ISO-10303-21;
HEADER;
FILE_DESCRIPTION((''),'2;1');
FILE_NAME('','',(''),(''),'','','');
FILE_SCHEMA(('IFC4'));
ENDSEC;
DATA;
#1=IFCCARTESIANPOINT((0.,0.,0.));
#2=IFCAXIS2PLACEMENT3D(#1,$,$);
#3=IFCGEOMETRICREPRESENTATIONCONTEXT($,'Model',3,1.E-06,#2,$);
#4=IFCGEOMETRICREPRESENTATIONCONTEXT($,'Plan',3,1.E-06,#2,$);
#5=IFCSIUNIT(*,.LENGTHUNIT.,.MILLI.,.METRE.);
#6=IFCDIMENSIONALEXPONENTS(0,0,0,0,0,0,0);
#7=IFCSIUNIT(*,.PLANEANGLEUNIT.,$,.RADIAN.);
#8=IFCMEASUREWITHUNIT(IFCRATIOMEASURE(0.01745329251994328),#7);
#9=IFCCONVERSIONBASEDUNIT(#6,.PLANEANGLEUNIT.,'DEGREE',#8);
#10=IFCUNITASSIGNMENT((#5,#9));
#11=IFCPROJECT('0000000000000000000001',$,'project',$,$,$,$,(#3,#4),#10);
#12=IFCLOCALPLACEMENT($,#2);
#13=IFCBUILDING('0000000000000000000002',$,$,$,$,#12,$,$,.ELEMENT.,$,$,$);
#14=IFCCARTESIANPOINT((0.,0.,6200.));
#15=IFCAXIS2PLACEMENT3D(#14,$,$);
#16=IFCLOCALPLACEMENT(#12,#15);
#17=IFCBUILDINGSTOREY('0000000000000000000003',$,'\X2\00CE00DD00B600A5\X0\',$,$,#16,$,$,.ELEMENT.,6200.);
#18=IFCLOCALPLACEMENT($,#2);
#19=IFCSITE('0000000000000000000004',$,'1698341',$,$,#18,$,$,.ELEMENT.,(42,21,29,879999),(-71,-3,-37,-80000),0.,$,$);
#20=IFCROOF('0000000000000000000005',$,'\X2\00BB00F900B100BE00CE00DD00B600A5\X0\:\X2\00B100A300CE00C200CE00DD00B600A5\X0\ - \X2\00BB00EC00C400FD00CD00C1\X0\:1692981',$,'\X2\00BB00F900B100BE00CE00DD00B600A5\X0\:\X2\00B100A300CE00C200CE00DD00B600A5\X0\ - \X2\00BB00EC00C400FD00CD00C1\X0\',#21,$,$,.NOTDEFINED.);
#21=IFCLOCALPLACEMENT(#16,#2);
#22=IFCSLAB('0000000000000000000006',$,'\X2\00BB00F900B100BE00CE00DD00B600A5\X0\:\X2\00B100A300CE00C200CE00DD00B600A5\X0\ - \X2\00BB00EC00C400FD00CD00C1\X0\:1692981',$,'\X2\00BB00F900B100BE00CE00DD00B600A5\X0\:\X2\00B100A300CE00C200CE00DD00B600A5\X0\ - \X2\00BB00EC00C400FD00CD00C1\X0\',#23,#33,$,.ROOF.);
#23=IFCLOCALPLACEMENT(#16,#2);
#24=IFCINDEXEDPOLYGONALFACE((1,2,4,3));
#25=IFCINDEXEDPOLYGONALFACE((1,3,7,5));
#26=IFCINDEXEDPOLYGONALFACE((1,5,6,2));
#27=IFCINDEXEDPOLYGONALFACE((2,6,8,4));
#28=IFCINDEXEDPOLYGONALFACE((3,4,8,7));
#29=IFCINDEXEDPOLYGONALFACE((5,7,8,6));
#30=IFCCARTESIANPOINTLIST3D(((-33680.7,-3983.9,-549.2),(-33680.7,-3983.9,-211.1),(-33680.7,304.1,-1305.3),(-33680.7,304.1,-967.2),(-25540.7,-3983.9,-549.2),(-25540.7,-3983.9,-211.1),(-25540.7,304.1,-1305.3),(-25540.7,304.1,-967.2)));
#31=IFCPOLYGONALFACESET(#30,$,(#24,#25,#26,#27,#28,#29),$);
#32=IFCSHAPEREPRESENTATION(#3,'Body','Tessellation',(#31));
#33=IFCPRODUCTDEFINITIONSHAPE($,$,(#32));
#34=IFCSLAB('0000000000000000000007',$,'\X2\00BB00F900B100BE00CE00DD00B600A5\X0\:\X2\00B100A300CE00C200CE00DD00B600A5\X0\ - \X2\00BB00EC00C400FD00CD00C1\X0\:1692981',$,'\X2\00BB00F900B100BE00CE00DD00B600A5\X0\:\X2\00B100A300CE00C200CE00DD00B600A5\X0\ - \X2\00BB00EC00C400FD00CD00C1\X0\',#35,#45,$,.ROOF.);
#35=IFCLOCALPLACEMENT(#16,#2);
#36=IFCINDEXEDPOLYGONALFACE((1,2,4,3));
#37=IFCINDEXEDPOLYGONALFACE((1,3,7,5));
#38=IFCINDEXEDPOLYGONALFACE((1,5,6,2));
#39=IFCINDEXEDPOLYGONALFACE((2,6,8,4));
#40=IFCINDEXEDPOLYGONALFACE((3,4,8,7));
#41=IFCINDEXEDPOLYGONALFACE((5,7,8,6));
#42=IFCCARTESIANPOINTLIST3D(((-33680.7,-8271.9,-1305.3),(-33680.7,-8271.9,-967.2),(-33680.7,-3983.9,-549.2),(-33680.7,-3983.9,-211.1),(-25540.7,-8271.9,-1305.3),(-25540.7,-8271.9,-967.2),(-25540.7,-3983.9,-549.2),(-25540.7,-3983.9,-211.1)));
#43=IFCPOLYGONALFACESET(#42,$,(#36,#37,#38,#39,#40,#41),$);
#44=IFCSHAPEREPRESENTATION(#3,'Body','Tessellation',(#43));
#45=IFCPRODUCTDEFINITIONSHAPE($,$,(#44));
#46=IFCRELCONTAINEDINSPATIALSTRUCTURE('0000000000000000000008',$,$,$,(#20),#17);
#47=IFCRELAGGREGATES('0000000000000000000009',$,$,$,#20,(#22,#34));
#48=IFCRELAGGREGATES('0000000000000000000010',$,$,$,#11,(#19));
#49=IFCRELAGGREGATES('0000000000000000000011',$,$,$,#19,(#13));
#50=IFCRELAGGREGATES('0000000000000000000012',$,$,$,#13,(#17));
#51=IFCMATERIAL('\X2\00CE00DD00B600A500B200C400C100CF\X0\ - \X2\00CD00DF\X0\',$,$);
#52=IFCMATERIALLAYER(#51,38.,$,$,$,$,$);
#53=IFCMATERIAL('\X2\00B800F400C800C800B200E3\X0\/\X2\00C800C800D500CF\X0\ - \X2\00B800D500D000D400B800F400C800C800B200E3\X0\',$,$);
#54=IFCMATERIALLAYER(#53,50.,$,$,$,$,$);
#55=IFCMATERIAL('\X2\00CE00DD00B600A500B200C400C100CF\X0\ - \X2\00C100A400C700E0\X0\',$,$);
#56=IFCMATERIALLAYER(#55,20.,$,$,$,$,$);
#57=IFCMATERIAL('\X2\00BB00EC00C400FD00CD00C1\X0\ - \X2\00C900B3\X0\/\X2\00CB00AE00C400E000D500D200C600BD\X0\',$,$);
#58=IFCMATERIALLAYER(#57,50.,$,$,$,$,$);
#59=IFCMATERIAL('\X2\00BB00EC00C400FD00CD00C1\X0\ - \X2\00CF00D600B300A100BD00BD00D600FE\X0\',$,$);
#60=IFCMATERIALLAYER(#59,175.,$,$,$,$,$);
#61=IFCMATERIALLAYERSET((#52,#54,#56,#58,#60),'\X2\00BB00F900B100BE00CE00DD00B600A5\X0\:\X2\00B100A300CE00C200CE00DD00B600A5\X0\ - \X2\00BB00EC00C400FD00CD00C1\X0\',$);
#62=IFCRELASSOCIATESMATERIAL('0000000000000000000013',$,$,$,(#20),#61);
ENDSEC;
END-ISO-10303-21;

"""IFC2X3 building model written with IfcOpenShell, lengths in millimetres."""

from ifc_helpers import new_model, entity, si_unit, converted_unit, frame, frame_2d, origin, place, context, project, spatial, rectangle, extrude, material, layer, layer_set, layer_usage, element, aggregate, save


model = new_model("IFC2X3")

# Units and contexts
model_context = context("Model", 3, precision=1e-06, world=origin())
plan_context = context("Plan", 3, precision=1e-06, world=origin())
ifc_project = project(units=[si_unit("LENGTHUNIT", "METRE", prefix="MILLI"), converted_unit("PLANEANGLEUNIT", "DEGREE", entity("IfcRatioMeasure", 0.01745329251994328), si_unit("PLANEANGLEUNIT", "RADIAN"), dimensions=[0, 0, 0, 0, 0, 0, 0])], contexts=[model_context, plan_context])

# Site, building, storey
site_placement = place(None, origin())
site = spatial("IfcSite", under=ifc_project, at=site_placement, Name="1698341", CompositionType="ELEMENT", RefLatitude=(42, 21, 29, 879999), RefLongitude=(-71, -3, -37, -80000), RefElevation=0.0)
building_placement = place(None, origin())
building = spatial("IfcBuilding", under=site, at=building_placement, CompositionType="ELEMENT")
storey_placement = place(building_placement, frame((0.0, 0.0, 6200.0)))
storey = spatial("IfcBuildingStorey", under=building, at=storey_placement, Name="ÎÝ¶¥", CompositionType="ELEMENT", Elevation=6200.0)

# Roof, slabs
ifc_material_1 = material(Name="ÎÝ¶¥²ÄÁÏ - Íß")
ifc_layer_1 = layer(ifc_material_1, 38.0)
ifc_material_2 = material(Name="¸ôÈÈ²ã/ÈÈÕÏ - ¸ÕÐÔ¸ôÈÈ²ã")
ifc_layer_2 = layer(ifc_material_2, 50.0)
ifc_material_3 = material(Name="ÎÝ¶¥²ÄÁÏ - Á¤Çà")
ifc_layer_3 = layer(ifc_material_3, 20.0)
ifc_material_4 = material(Name="»ìÄýÍÁ - É³/Ë®ÄàÕÒÆ½")
ifc_layer_4 = layer(ifc_material_4, 50.0)
ifc_material_5 = material(Name="»ìÄýÍÁ - ÏÖ³¡½½Öþ")
ifc_layer_5 = layer(ifc_material_5, 175.0)
ifc_layer_set = layer_set([ifc_layer_1, ifc_layer_2, ifc_layer_3, ifc_layer_4, ifc_layer_5], Name="»ù±¾ÎÝ¶¥:±£ÎÂÎÝ¶¥ - »ìÄýÍÁ")
ifc_layer_usage = layer_usage(ifc_layer_set, "AXIS3", "NEGATIVE", 0.0)
roof_placement = place(storey_placement, origin())
roof = element("IfcRoof", 1, at=roof_placement, inside=storey, material=ifc_layer_usage, Name="»ù±¾ÎÝ¶¥:±£ÎÂÎÝ¶¥ - »ìÄýÍÁ:1692981", ObjectType="»ù±¾ÎÝ¶¥:±£ÎÂÎÝ¶¥ - »ìÄýÍÁ", ShapeType="NOTDEFINED")
slab_1_placement = place(roof_placement, frame((-33680.7, -8271.9, -1305.3)))
slab_1 = element("IfcSlab", 2, at=slab_1_placement, Name="»ù±¾ÎÝ¶¥:±£ÎÂÎÝ¶¥ - »ìÄýÍÁ:1692981", ObjectType="»ù±¾ÎÝ¶¥:±£ÎÂÎÝ¶¥ - »ìÄýÍÁ", PredefinedType="ROOF", context=model_context, shape_type="SweptSolid", body=[
    extrude(rectangle(XDim=8140.0, YDim=4354.1, at=frame_2d((0.0, 0.0), x_axis=(-1.0, 0.0))), frame((4070.0, 6431.9, 378.0), z_axis=(0.0, 0.173648, 0.984808), x_axis=(1.0, 0.0, 0.0)), (0.0, -0.173648, 0.984808), 338.1),
])
slab_2_placement = place(roof_placement, frame((-33680.7, -8271.9, -1305.3)))
slab_2 = element("IfcSlab", 3, at=slab_2_placement, Name="»ù±¾ÎÝ¶¥:±£ÎÂÎÝ¶¥ - »ìÄýÍÁ:1692981", ObjectType="»ù±¾ÎÝ¶¥:±£ÎÂÎÝ¶¥ - »ìÄýÍÁ", PredefinedType="ROOF", context=model_context, shape_type="SweptSolid", body=[
    extrude(rectangle(XDim=8140.0, YDim=4354.1, at=frame_2d((0.0, 0.0), x_axis=(-1.0, 0.0))), frame((4070.0, 2144.0, 378.0), z_axis=(0.0, -0.173648, 0.984808), x_axis=(1.0, 0.0, 0.0)), (0.0, 0.173648, 0.984808), 338.1),
])
aggregate(roof, [slab_1, slab_2])

save(model, "model.ifc")
